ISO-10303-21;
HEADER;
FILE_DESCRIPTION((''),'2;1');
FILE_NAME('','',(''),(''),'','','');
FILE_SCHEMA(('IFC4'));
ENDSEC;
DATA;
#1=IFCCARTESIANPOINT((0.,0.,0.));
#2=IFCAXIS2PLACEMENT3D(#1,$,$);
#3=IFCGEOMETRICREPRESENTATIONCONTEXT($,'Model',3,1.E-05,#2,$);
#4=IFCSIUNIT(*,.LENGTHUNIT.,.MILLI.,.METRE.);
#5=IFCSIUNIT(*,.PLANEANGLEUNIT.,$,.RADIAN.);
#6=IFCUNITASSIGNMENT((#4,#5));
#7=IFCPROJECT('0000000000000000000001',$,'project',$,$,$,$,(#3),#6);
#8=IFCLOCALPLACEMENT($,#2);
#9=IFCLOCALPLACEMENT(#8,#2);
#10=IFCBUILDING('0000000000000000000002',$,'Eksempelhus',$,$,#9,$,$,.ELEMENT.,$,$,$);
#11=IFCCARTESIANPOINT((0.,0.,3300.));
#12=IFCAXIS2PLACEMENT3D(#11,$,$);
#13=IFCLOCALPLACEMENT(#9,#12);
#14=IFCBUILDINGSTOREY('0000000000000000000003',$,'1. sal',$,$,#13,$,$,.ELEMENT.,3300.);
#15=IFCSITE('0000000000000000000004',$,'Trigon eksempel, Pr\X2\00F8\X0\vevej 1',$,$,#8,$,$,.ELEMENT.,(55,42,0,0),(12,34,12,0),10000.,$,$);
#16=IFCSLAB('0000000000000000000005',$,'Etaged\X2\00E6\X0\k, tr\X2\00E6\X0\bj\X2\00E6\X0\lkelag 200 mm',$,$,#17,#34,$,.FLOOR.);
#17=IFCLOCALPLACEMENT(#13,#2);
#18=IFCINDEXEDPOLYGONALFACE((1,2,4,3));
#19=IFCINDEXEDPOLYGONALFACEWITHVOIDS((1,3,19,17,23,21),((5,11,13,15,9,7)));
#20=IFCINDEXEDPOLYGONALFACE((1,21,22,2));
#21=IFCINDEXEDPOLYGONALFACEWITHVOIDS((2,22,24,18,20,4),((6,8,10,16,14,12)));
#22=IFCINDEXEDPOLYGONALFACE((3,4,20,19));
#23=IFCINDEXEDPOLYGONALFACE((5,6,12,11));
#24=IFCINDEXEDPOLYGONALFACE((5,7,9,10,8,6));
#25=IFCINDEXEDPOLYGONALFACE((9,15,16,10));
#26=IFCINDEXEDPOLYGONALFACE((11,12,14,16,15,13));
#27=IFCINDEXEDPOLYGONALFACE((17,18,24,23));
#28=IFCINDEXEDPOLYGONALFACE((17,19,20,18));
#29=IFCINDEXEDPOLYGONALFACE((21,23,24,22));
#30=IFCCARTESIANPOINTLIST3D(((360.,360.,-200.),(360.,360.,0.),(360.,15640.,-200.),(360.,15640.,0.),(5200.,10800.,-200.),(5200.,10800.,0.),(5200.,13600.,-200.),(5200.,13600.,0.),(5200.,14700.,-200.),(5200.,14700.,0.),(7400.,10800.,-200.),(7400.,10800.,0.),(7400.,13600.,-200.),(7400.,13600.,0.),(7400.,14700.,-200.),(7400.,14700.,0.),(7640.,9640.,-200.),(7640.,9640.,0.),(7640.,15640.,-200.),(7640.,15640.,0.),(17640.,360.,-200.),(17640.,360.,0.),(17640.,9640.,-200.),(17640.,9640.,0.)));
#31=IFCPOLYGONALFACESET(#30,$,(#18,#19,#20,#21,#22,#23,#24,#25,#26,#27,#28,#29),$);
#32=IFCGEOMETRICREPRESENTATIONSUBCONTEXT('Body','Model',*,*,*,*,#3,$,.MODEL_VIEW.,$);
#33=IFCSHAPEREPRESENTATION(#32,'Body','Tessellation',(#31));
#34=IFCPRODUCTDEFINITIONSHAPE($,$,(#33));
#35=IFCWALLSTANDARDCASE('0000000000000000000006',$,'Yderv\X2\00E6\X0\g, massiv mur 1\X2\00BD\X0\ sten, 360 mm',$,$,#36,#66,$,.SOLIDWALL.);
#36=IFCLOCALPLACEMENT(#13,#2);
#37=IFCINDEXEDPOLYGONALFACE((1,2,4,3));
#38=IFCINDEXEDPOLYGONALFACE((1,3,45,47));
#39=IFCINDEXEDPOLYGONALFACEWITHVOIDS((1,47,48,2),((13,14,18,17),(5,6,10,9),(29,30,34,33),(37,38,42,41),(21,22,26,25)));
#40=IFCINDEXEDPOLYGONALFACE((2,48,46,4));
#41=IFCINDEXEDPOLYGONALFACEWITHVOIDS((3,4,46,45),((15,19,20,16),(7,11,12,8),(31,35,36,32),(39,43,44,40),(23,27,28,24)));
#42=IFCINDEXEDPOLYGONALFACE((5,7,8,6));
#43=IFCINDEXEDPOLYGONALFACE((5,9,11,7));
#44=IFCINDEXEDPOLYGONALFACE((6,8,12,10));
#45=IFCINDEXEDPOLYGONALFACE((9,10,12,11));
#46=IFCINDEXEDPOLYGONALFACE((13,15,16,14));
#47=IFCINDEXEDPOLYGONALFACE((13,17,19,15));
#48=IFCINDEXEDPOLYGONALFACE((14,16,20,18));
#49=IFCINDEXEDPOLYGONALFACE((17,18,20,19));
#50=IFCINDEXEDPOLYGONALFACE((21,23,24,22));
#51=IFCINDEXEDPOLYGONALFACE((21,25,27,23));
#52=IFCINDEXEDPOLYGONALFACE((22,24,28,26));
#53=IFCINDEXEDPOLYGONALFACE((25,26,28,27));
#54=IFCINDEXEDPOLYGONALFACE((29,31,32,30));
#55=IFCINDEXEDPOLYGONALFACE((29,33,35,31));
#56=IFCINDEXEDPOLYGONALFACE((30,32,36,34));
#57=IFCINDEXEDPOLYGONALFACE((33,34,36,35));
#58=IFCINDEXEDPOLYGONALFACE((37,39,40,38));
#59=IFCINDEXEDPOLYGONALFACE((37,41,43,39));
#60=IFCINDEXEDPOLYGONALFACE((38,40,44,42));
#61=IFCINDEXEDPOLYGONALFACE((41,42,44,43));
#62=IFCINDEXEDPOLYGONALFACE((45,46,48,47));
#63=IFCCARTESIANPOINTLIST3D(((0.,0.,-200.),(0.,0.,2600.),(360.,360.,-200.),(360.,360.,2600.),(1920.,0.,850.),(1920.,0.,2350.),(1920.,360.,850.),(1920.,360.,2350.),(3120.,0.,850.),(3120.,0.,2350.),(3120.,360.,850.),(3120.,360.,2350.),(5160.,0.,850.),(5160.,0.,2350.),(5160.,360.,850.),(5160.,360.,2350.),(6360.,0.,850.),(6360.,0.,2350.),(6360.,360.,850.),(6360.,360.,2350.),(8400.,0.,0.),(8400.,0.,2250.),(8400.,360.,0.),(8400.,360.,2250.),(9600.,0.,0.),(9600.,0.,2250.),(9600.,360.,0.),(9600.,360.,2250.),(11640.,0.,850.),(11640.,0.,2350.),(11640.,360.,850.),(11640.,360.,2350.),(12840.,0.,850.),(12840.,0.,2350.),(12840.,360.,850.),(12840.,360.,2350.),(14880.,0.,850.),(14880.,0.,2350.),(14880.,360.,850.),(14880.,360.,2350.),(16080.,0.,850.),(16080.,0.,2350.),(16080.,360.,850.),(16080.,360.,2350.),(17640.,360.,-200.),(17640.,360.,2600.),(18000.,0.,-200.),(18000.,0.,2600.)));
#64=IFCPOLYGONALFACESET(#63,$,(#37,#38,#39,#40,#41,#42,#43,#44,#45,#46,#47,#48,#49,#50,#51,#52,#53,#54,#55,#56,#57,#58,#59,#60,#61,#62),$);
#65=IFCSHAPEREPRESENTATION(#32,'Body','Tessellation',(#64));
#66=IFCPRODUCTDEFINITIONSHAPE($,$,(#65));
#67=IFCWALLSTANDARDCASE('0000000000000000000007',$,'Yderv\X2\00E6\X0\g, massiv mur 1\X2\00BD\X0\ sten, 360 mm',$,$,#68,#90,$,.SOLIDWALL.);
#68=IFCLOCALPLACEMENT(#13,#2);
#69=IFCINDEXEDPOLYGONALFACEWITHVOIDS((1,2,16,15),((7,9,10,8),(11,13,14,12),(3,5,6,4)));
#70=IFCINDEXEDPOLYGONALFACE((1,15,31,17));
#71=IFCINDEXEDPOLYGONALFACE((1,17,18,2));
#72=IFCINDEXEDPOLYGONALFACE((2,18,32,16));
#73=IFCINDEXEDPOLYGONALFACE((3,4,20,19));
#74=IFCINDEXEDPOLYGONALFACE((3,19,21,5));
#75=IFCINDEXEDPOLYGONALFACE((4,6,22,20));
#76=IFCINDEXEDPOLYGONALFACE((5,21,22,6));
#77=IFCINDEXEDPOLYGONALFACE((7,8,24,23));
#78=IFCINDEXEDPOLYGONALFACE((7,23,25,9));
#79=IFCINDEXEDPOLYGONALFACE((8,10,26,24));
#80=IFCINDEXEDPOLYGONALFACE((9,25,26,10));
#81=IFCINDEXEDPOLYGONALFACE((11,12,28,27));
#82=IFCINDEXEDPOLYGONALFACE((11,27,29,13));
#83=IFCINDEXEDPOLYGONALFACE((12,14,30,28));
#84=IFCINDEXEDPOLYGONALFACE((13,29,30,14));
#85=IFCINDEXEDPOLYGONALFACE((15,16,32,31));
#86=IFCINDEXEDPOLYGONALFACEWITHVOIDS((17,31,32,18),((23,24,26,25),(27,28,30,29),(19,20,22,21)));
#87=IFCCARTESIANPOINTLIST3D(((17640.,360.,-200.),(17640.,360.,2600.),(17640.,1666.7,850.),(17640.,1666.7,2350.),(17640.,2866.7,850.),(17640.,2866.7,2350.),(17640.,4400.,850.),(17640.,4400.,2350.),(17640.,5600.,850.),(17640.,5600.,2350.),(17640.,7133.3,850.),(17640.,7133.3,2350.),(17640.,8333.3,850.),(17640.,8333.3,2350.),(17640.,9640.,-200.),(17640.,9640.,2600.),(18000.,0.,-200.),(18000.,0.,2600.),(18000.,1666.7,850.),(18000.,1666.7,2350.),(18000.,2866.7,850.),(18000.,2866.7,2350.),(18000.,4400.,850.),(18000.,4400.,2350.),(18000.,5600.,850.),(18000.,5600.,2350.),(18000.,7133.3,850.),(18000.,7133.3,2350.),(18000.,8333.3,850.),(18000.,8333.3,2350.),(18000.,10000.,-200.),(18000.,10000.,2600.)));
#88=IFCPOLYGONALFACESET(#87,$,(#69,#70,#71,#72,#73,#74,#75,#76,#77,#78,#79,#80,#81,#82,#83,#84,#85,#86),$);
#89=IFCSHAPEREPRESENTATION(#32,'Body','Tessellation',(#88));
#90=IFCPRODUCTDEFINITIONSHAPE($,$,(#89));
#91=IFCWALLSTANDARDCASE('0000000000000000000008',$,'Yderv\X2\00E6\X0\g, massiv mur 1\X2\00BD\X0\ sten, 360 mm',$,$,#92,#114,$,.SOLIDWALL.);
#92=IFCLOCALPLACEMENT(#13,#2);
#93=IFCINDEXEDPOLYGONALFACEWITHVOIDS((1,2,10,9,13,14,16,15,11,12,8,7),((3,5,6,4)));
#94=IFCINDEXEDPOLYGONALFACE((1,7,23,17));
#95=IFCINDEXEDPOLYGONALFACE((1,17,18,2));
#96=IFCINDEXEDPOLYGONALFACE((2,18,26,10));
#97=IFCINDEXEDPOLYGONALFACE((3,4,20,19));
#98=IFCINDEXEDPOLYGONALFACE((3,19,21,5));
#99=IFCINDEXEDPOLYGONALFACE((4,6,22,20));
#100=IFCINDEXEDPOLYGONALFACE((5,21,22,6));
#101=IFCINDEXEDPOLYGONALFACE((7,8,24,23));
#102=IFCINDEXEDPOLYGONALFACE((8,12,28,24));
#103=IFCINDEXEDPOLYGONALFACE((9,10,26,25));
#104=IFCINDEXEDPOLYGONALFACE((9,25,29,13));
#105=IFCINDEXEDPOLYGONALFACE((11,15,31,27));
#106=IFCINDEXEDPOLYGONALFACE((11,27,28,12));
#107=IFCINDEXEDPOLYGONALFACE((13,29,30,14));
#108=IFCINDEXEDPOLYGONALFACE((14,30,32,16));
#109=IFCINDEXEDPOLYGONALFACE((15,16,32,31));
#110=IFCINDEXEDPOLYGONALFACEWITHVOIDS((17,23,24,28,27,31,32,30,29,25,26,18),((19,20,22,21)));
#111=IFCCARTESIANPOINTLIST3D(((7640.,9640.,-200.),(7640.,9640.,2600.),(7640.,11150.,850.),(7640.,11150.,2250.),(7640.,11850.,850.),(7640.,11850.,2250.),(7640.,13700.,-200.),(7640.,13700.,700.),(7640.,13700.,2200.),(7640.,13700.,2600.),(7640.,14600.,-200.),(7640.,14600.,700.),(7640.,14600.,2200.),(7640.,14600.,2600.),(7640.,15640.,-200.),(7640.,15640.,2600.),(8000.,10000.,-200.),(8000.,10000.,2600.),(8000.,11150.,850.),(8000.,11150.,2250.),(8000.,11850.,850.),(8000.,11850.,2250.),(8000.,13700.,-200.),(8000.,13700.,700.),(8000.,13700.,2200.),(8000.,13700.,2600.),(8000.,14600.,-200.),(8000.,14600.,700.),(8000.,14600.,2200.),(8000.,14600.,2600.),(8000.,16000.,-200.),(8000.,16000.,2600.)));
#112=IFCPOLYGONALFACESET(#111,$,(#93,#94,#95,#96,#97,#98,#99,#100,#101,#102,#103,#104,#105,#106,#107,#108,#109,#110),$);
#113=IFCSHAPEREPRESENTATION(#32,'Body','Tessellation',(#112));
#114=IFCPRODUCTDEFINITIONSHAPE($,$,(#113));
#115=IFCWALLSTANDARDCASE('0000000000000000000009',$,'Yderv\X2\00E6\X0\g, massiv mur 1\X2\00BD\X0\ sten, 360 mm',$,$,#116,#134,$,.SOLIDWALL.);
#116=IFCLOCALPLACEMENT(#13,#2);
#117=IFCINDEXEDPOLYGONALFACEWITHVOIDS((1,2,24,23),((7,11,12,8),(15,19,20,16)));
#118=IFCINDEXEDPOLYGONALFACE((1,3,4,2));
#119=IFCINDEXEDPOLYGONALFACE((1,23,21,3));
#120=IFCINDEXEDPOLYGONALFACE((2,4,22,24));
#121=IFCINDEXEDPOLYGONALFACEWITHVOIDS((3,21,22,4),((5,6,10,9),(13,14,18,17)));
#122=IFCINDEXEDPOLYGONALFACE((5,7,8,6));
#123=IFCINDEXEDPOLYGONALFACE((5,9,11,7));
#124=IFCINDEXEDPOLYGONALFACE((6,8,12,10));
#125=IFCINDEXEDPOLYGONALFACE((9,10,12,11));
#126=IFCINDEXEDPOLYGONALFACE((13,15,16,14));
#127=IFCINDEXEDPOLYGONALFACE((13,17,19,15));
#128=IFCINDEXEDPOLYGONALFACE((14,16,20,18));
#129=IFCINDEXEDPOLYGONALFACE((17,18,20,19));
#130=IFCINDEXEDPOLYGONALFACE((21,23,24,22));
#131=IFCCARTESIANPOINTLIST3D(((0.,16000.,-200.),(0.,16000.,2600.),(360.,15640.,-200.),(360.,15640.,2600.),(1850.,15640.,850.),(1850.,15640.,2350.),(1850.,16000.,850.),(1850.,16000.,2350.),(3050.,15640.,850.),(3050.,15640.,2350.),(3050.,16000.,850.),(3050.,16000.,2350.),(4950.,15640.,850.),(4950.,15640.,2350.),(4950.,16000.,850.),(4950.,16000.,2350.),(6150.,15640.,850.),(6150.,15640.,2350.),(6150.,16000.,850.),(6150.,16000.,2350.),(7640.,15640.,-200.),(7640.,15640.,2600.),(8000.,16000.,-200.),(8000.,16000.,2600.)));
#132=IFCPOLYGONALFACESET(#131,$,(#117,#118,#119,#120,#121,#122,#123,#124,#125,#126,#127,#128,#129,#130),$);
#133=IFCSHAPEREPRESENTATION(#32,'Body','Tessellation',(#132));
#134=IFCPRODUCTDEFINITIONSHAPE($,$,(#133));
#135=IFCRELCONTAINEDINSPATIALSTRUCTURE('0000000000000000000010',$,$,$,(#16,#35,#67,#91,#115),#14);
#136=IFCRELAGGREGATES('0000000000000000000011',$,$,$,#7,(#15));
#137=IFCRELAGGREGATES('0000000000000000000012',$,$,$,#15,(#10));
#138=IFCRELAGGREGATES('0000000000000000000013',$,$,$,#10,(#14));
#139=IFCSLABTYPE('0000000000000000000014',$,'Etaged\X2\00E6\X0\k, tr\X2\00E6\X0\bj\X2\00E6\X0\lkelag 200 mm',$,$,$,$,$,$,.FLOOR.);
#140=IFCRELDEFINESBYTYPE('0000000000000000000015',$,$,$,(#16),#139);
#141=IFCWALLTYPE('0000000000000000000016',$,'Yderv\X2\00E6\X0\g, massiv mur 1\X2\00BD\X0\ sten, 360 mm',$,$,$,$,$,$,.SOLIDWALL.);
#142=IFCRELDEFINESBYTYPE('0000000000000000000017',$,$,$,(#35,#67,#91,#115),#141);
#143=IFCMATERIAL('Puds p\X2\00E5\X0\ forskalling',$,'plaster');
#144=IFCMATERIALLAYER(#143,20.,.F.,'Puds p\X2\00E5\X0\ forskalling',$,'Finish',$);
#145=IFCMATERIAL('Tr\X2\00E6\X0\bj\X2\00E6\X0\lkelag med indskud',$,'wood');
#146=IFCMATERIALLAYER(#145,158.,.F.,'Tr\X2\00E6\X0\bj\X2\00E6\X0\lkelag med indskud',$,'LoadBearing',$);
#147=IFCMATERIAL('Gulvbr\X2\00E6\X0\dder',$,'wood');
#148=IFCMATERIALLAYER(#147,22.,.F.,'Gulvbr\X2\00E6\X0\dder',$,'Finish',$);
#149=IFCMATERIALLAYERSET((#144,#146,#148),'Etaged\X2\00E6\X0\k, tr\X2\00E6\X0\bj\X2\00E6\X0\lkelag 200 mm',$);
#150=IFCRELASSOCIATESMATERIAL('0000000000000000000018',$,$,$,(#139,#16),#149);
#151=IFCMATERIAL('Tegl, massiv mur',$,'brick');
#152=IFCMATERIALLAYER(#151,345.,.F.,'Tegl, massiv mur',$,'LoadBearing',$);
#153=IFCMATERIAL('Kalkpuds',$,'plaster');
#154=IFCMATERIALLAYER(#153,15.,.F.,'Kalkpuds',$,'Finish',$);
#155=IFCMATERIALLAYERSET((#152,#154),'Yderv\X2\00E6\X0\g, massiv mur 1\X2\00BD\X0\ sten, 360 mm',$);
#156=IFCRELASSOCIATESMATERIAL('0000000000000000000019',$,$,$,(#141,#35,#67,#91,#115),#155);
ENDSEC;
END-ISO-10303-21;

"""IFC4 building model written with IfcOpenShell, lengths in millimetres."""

from ifc_helpers import new_model, si_unit, frame, origin, place, context, subcontext, project, spatial, polyline, rectangle, outline, extrude, material, layer, layer_set, layer_usage, type_object, element, save


model = new_model("IFC4")

# Units and contexts
model_context = context("Model", 3, precision=1e-05, world=origin())
body_context = subcontext(model_context, "Body", "Model", "MODEL_VIEW")
ifc_project = project(units=[si_unit("LENGTHUNIT", "METRE", prefix="MILLI"), si_unit("PLANEANGLEUNIT", "RADIAN")], contexts=[model_context])

# Site, building, storey
site_placement = place(None, origin())
site = spatial("IfcSite", under=ifc_project, at=site_placement, Name="Trigon eksempel, Prøvevej 1", CompositionType="ELEMENT", RefLatitude=(55, 42, 0, 0), RefLongitude=(12, 34, 12, 0), RefElevation=10000.0)
building_placement = place(site_placement, origin())
building = spatial("IfcBuilding", under=site, at=building_placement, Name="Eksempelhus", CompositionType="ELEMENT")
storey_placement = place(building_placement, frame((0.0, 0.0, 3300.0)))
storey = spatial("IfcBuildingStorey", under=building, at=storey_placement, Name="1. sal", CompositionType="ELEMENT", Elevation=3300.0)

# Slab
ifc_material_1 = material(Name="Puds på forskalling", Category="plaster")
ifc_layer_1 = layer(ifc_material_1, 20.0, ventilated=False, Name="Puds på forskalling", Category="Finish")
ifc_material_2 = material(Name="Træbjælkelag med indskud", Category="wood")
ifc_layer_2 = layer(ifc_material_2, 158.0, ventilated=False, Name="Træbjælkelag med indskud", Category="LoadBearing")
ifc_material_3 = material(Name="Gulvbrædder", Category="wood")
ifc_layer_3 = layer(ifc_material_3, 22.0, ventilated=False, Name="Gulvbrædder", Category="Finish")
ifc_layer_set_1 = layer_set([ifc_layer_1, ifc_layer_2, ifc_layer_3], Name="Etagedæk, træbjælkelag 200 mm")
ifc_layer_usage_1 = layer_usage(ifc_layer_set_1, "AXIS3", "POSITIVE", 0.0)
slab_type = type_object("IfcSlabType", Name="Etagedæk, træbjælkelag 200 mm", PredefinedType="FLOOR", material=ifc_layer_set_1)
slab_placement = place(storey_placement, frame((0.0, 0.0, -200.0)))
element("IfcSlab", 1, at=slab_placement, inside=storey, type_object=slab_type, material=ifc_layer_usage_1, Name="Etagedæk, træbjælkelag 200 mm", PredefinedType="FLOOR", context=body_context, shape_type="SweptSolid", body=[
    extrude(outline(polyline([(360.0, 360.0), (17640.0, 360.0), (17640.0, 9640.0), (7640.0, 9640.0), (7640.0, 15640.0), (360.0, 15640.0), (360.0, 360.0)]), holes=[polyline([(7400.0, 10800.0), (7400.0, 13600.0), (7400.0, 14700.0), (5200.0, 14700.0), (5200.0, 13600.0), (5200.0, 10800.0), (7400.0, 10800.0)])]), origin(), (0.0, 0.0, 1.0), 200.0),
])

# Walls, openings
ifc_material_4 = material(Name="Tegl, massiv mur", Category="brick")
ifc_layer_4 = layer(ifc_material_4, 345.0, ventilated=False, Name="Tegl, massiv mur", Category="LoadBearing")
ifc_material_5 = material(Name="Kalkpuds", Category="plaster")
ifc_layer_5 = layer(ifc_material_5, 15.0, ventilated=False, Name="Kalkpuds", Category="Finish")
ifc_layer_set_2 = layer_set([ifc_layer_4, ifc_layer_5], Name="Ydervæg, massiv mur 1½ sten, 360 mm")
ifc_layer_usage_2 = layer_usage(ifc_layer_set_2, "AXIS2", "POSITIVE", 0.0)
wall_type_1 = type_object("IfcWallType", Name="Ydervæg, massiv mur 1½ sten, 360 mm", PredefinedType="SOLIDWALL", material=ifc_layer_set_2)
wall_1_placement = place(storey_placement, frame((0.0, 0.0, -200.0)))
wall_1 = element("IfcWallStandardCase", 2, at=wall_1_placement, inside=storey, type_object=wall_type_1, material=ifc_layer_usage_2, Name="Ydervæg, massiv mur 1½ sten, 360 mm", PredefinedType="SOLIDWALL", context=body_context, shape_type="SweptSolid", body=[
    extrude(outline(polyline([(0.0, 0.0), (18000.0, 0.0), (17640.0, 360.0), (360.0, 360.0), (0.0, 0.0)])), origin(), (0.0, 0.0, 1.0), 2800.0),
])
opening_1_placement = place(wall_1_placement, frame((1920.0, 0.0, 1050.0)))
element("IfcOpeningElement", 3, at=opening_1_placement, cuts=wall_1, PredefinedType="OPENING", context=body_context, shape_type="SweptSolid", body=[
    extrude(rectangle(XDim=1200.0, YDim=1500.0), frame((600.0, 0.0, 750.0), z_axis=(0.0, 1.0, 0.0), x_axis=(1.0, 0.0, 0.0)), (0.0, 0.0, 1.0), 360.0),
])
opening_2_placement = place(wall_1_placement, frame((5160.0, 0.0, 1050.0)))
element("IfcOpeningElement", 4, at=opening_2_placement, cuts=wall_1, PredefinedType="OPENING", context=body_context, shape_type="SweptSolid", body=[
    extrude(rectangle(XDim=1200.0, YDim=1500.0), frame((600.0, 0.0, 750.0), z_axis=(0.0, 1.0, 0.0), x_axis=(1.0, 0.0, 0.0)), (0.0, 0.0, 1.0), 360.0),
])
opening_3_placement = place(wall_1_placement, frame((11640.0, 0.0, 1050.0)))
element("IfcOpeningElement", 5, at=opening_3_placement, cuts=wall_1, PredefinedType="OPENING", context=body_context, shape_type="SweptSolid", body=[
    extrude(rectangle(XDim=1200.0, YDim=1500.0), frame((600.0, 0.0, 750.0), z_axis=(0.0, 1.0, 0.0), x_axis=(1.0, 0.0, 0.0)), (0.0, 0.0, 1.0), 360.0),
])
opening_4_placement = place(wall_1_placement, frame((14880.0, 0.0, 1050.0)))
element("IfcOpeningElement", 6, at=opening_4_placement, cuts=wall_1, PredefinedType="OPENING", context=body_context, shape_type="SweptSolid", body=[
    extrude(rectangle(XDim=1200.0, YDim=1500.0), frame((600.0, 0.0, 750.0), z_axis=(0.0, 1.0, 0.0), x_axis=(1.0, 0.0, 0.0)), (0.0, 0.0, 1.0), 360.0),
])
opening_5_placement = place(wall_1_placement, frame((8400.0, 0.0, 200.0)))
element("IfcOpeningElement", 7, at=opening_5_placement, cuts=wall_1, PredefinedType="OPENING", context=body_context, shape_type="SweptSolid", body=[
    extrude(rectangle(XDim=1200.0, YDim=2250.0), frame((600.0, 0.0, 1125.0), z_axis=(0.0, 1.0, 0.0), x_axis=(1.0, 0.0, 0.0)), (0.0, 0.0, 1.0), 360.0),
])
wall_2_placement = place(storey_placement, frame((18000.0, 0.0, -200.0), z_axis=(0.0, 0.0, 1.0), x_axis=(0.0, 1.0, 0.0)))
wall_2 = element("IfcWallStandardCase", 8, at=wall_2_placement, inside=storey, type_object=wall_type_1, material=ifc_layer_usage_2, Name="Ydervæg, massiv mur 1½ sten, 360 mm", PredefinedType="SOLIDWALL", context=body_context, shape_type="SweptSolid", body=[
    extrude(outline(polyline([(0.0, 0.0), (10000.0, 0.0), (9640.0, 360.0), (360.0, 360.0), (0.0, 0.0)])), origin(), (0.0, 0.0, 1.0), 2800.0),
])
opening_6_placement = place(wall_2_placement, frame((1666.7, 0.0, 1050.0)))
element("IfcOpeningElement", 9, at=opening_6_placement, cuts=wall_2, PredefinedType="OPENING", context=body_context, shape_type="SweptSolid", body=[
    extrude(rectangle(XDim=1200.0, YDim=1500.0), frame((600.0, 0.0, 750.0), z_axis=(0.0, 1.0, 0.0), x_axis=(1.0, 0.0, 0.0)), (0.0, 0.0, 1.0), 360.0),
])
opening_7_placement = place(wall_2_placement, frame((4400.0, 0.0, 1050.0)))
element("IfcOpeningElement", 10, at=opening_7_placement, cuts=wall_2, PredefinedType="OPENING", context=body_context, shape_type="SweptSolid", body=[
    extrude(rectangle(XDim=1200.0, YDim=1500.0), frame((600.0, 0.0, 750.0), z_axis=(0.0, 1.0, 0.0), x_axis=(1.0, 0.0, 0.0)), (0.0, 0.0, 1.0), 360.0),
])
opening_8_placement = place(wall_2_placement, frame((7133.3, 0.0, 1050.0)))
element("IfcOpeningElement", 11, at=opening_8_placement, cuts=wall_2, PredefinedType="OPENING", context=body_context, shape_type="SweptSolid", body=[
    extrude(rectangle(XDim=1200.0, YDim=1500.0), frame((600.0, 0.0, 750.0), z_axis=(0.0, 1.0, 0.0), x_axis=(1.0, 0.0, 0.0)), (0.0, 0.0, 1.0), 360.0),
])
wall_3_placement = place(storey_placement, frame((8000.0, 10000.0, -200.0), z_axis=(0.0, 0.0, 1.0), x_axis=(0.0, 1.0, 0.0)))
wall_3 = element("IfcWallStandardCase", 12, at=wall_3_placement, inside=storey, type_object=wall_type_1, material=ifc_layer_usage_2, Name="Ydervæg, massiv mur 1½ sten, 360 mm", PredefinedType="SOLIDWALL", context=body_context, shape_type="SweptSolid", body=[
    extrude(outline(polyline([(0.0, 0.0), (6000.0, 0.0), (5640.0, 360.0), (-360.0, 360.0), (0.0, 0.0)])), origin(), (0.0, 0.0, 1.0), 2800.0),
])
opening_9_placement = place(wall_3_placement, frame((1150.0, 0.0, 1050.0)))
element("IfcOpeningElement", 13, at=opening_9_placement, cuts=wall_3, PredefinedType="OPENING", context=body_context, shape_type="SweptSolid", body=[
    extrude(rectangle(XDim=700.0, YDim=1400.0), frame((350.0, 0.0, 700.0), z_axis=(0.0, 1.0, 0.0), x_axis=(1.0, 0.0, 0.0)), (0.0, 0.0, 1.0), 360.0),
])
opening_10_placement = place(wall_3_placement, frame((3700.0, 0.0, 0.0)))
element("IfcOpeningElement", 14, at=opening_10_placement, cuts=wall_3, PredefinedType="OPENING", context=body_context, shape_type="SweptSolid", body=[
    extrude(rectangle(XDim=900.0, YDim=900.0), frame((450.0, 0.0, 450.0), z_axis=(0.0, 1.0, 0.0), x_axis=(1.0, 0.0, 0.0)), (0.0, 0.0, 1.0), 360.0),
])
opening_11_placement = place(wall_3_placement, frame((3700.0, 0.0, 2400.0)))
element("IfcOpeningElement", 15, at=opening_11_placement, cuts=wall_3, PredefinedType="OPENING", context=body_context, shape_type="SweptSolid", body=[
    extrude(rectangle(XDim=900.0, YDim=400.0), frame((450.0, 0.0, 200.0), z_axis=(0.0, 1.0, 0.0), x_axis=(1.0, 0.0, 0.0)), (0.0, 0.0, 1.0), 360.0),
])
wall_4_placement = place(storey_placement, frame((8000.0, 16000.0, -200.0), z_axis=(0.0, 0.0, 1.0), x_axis=(-1.0, 0.0, 0.0)))
wall_4 = element("IfcWallStandardCase", 16, at=wall_4_placement, inside=storey, type_object=wall_type_1, material=ifc_layer_usage_2, Name="Ydervæg, massiv mur 1½ sten, 360 mm", PredefinedType="SOLIDWALL", context=body_context, shape_type="SweptSolid", body=[
    extrude(outline(polyline([(0.0, 0.0), (8000.0, 0.0), (7640.0, 360.0), (360.0, 360.0), (0.0, 0.0)])), origin(), (0.0, 0.0, 1.0), 2800.0),
])
opening_12_placement = place(wall_4_placement, frame((1850.0, 0.0, 1050.0)))
element("IfcOpeningElement", 17, at=opening_12_placement, cuts=wall_4, PredefinedType="OPENING", context=body_context, shape_type="SweptSolid", body=[
    extrude(rectangle(XDim=1200.0, YDim=1500.0), frame((600.0, 0.0, 750.0), z_axis=(0.0, 1.0, 0.0), x_axis=(1.0, 0.0, 0.0)), (0.0, 0.0, 1.0), 360.0),
])
opening_13_placement = place(wall_4_placement, frame((4950.0, 0.0, 1050.0)))
element("IfcOpeningElement", 18, at=opening_13_placement, cuts=wall_4, PredefinedType="OPENING", context=body_context, shape_type="SweptSolid", body=[
    extrude(rectangle(XDim=1200.0, YDim=1500.0), frame((600.0, 0.0, 750.0), z_axis=(0.0, 1.0, 0.0), x_axis=(1.0, 0.0, 0.0)), (0.0, 0.0, 1.0), 360.0),
])

save(model, "model.ifc")
